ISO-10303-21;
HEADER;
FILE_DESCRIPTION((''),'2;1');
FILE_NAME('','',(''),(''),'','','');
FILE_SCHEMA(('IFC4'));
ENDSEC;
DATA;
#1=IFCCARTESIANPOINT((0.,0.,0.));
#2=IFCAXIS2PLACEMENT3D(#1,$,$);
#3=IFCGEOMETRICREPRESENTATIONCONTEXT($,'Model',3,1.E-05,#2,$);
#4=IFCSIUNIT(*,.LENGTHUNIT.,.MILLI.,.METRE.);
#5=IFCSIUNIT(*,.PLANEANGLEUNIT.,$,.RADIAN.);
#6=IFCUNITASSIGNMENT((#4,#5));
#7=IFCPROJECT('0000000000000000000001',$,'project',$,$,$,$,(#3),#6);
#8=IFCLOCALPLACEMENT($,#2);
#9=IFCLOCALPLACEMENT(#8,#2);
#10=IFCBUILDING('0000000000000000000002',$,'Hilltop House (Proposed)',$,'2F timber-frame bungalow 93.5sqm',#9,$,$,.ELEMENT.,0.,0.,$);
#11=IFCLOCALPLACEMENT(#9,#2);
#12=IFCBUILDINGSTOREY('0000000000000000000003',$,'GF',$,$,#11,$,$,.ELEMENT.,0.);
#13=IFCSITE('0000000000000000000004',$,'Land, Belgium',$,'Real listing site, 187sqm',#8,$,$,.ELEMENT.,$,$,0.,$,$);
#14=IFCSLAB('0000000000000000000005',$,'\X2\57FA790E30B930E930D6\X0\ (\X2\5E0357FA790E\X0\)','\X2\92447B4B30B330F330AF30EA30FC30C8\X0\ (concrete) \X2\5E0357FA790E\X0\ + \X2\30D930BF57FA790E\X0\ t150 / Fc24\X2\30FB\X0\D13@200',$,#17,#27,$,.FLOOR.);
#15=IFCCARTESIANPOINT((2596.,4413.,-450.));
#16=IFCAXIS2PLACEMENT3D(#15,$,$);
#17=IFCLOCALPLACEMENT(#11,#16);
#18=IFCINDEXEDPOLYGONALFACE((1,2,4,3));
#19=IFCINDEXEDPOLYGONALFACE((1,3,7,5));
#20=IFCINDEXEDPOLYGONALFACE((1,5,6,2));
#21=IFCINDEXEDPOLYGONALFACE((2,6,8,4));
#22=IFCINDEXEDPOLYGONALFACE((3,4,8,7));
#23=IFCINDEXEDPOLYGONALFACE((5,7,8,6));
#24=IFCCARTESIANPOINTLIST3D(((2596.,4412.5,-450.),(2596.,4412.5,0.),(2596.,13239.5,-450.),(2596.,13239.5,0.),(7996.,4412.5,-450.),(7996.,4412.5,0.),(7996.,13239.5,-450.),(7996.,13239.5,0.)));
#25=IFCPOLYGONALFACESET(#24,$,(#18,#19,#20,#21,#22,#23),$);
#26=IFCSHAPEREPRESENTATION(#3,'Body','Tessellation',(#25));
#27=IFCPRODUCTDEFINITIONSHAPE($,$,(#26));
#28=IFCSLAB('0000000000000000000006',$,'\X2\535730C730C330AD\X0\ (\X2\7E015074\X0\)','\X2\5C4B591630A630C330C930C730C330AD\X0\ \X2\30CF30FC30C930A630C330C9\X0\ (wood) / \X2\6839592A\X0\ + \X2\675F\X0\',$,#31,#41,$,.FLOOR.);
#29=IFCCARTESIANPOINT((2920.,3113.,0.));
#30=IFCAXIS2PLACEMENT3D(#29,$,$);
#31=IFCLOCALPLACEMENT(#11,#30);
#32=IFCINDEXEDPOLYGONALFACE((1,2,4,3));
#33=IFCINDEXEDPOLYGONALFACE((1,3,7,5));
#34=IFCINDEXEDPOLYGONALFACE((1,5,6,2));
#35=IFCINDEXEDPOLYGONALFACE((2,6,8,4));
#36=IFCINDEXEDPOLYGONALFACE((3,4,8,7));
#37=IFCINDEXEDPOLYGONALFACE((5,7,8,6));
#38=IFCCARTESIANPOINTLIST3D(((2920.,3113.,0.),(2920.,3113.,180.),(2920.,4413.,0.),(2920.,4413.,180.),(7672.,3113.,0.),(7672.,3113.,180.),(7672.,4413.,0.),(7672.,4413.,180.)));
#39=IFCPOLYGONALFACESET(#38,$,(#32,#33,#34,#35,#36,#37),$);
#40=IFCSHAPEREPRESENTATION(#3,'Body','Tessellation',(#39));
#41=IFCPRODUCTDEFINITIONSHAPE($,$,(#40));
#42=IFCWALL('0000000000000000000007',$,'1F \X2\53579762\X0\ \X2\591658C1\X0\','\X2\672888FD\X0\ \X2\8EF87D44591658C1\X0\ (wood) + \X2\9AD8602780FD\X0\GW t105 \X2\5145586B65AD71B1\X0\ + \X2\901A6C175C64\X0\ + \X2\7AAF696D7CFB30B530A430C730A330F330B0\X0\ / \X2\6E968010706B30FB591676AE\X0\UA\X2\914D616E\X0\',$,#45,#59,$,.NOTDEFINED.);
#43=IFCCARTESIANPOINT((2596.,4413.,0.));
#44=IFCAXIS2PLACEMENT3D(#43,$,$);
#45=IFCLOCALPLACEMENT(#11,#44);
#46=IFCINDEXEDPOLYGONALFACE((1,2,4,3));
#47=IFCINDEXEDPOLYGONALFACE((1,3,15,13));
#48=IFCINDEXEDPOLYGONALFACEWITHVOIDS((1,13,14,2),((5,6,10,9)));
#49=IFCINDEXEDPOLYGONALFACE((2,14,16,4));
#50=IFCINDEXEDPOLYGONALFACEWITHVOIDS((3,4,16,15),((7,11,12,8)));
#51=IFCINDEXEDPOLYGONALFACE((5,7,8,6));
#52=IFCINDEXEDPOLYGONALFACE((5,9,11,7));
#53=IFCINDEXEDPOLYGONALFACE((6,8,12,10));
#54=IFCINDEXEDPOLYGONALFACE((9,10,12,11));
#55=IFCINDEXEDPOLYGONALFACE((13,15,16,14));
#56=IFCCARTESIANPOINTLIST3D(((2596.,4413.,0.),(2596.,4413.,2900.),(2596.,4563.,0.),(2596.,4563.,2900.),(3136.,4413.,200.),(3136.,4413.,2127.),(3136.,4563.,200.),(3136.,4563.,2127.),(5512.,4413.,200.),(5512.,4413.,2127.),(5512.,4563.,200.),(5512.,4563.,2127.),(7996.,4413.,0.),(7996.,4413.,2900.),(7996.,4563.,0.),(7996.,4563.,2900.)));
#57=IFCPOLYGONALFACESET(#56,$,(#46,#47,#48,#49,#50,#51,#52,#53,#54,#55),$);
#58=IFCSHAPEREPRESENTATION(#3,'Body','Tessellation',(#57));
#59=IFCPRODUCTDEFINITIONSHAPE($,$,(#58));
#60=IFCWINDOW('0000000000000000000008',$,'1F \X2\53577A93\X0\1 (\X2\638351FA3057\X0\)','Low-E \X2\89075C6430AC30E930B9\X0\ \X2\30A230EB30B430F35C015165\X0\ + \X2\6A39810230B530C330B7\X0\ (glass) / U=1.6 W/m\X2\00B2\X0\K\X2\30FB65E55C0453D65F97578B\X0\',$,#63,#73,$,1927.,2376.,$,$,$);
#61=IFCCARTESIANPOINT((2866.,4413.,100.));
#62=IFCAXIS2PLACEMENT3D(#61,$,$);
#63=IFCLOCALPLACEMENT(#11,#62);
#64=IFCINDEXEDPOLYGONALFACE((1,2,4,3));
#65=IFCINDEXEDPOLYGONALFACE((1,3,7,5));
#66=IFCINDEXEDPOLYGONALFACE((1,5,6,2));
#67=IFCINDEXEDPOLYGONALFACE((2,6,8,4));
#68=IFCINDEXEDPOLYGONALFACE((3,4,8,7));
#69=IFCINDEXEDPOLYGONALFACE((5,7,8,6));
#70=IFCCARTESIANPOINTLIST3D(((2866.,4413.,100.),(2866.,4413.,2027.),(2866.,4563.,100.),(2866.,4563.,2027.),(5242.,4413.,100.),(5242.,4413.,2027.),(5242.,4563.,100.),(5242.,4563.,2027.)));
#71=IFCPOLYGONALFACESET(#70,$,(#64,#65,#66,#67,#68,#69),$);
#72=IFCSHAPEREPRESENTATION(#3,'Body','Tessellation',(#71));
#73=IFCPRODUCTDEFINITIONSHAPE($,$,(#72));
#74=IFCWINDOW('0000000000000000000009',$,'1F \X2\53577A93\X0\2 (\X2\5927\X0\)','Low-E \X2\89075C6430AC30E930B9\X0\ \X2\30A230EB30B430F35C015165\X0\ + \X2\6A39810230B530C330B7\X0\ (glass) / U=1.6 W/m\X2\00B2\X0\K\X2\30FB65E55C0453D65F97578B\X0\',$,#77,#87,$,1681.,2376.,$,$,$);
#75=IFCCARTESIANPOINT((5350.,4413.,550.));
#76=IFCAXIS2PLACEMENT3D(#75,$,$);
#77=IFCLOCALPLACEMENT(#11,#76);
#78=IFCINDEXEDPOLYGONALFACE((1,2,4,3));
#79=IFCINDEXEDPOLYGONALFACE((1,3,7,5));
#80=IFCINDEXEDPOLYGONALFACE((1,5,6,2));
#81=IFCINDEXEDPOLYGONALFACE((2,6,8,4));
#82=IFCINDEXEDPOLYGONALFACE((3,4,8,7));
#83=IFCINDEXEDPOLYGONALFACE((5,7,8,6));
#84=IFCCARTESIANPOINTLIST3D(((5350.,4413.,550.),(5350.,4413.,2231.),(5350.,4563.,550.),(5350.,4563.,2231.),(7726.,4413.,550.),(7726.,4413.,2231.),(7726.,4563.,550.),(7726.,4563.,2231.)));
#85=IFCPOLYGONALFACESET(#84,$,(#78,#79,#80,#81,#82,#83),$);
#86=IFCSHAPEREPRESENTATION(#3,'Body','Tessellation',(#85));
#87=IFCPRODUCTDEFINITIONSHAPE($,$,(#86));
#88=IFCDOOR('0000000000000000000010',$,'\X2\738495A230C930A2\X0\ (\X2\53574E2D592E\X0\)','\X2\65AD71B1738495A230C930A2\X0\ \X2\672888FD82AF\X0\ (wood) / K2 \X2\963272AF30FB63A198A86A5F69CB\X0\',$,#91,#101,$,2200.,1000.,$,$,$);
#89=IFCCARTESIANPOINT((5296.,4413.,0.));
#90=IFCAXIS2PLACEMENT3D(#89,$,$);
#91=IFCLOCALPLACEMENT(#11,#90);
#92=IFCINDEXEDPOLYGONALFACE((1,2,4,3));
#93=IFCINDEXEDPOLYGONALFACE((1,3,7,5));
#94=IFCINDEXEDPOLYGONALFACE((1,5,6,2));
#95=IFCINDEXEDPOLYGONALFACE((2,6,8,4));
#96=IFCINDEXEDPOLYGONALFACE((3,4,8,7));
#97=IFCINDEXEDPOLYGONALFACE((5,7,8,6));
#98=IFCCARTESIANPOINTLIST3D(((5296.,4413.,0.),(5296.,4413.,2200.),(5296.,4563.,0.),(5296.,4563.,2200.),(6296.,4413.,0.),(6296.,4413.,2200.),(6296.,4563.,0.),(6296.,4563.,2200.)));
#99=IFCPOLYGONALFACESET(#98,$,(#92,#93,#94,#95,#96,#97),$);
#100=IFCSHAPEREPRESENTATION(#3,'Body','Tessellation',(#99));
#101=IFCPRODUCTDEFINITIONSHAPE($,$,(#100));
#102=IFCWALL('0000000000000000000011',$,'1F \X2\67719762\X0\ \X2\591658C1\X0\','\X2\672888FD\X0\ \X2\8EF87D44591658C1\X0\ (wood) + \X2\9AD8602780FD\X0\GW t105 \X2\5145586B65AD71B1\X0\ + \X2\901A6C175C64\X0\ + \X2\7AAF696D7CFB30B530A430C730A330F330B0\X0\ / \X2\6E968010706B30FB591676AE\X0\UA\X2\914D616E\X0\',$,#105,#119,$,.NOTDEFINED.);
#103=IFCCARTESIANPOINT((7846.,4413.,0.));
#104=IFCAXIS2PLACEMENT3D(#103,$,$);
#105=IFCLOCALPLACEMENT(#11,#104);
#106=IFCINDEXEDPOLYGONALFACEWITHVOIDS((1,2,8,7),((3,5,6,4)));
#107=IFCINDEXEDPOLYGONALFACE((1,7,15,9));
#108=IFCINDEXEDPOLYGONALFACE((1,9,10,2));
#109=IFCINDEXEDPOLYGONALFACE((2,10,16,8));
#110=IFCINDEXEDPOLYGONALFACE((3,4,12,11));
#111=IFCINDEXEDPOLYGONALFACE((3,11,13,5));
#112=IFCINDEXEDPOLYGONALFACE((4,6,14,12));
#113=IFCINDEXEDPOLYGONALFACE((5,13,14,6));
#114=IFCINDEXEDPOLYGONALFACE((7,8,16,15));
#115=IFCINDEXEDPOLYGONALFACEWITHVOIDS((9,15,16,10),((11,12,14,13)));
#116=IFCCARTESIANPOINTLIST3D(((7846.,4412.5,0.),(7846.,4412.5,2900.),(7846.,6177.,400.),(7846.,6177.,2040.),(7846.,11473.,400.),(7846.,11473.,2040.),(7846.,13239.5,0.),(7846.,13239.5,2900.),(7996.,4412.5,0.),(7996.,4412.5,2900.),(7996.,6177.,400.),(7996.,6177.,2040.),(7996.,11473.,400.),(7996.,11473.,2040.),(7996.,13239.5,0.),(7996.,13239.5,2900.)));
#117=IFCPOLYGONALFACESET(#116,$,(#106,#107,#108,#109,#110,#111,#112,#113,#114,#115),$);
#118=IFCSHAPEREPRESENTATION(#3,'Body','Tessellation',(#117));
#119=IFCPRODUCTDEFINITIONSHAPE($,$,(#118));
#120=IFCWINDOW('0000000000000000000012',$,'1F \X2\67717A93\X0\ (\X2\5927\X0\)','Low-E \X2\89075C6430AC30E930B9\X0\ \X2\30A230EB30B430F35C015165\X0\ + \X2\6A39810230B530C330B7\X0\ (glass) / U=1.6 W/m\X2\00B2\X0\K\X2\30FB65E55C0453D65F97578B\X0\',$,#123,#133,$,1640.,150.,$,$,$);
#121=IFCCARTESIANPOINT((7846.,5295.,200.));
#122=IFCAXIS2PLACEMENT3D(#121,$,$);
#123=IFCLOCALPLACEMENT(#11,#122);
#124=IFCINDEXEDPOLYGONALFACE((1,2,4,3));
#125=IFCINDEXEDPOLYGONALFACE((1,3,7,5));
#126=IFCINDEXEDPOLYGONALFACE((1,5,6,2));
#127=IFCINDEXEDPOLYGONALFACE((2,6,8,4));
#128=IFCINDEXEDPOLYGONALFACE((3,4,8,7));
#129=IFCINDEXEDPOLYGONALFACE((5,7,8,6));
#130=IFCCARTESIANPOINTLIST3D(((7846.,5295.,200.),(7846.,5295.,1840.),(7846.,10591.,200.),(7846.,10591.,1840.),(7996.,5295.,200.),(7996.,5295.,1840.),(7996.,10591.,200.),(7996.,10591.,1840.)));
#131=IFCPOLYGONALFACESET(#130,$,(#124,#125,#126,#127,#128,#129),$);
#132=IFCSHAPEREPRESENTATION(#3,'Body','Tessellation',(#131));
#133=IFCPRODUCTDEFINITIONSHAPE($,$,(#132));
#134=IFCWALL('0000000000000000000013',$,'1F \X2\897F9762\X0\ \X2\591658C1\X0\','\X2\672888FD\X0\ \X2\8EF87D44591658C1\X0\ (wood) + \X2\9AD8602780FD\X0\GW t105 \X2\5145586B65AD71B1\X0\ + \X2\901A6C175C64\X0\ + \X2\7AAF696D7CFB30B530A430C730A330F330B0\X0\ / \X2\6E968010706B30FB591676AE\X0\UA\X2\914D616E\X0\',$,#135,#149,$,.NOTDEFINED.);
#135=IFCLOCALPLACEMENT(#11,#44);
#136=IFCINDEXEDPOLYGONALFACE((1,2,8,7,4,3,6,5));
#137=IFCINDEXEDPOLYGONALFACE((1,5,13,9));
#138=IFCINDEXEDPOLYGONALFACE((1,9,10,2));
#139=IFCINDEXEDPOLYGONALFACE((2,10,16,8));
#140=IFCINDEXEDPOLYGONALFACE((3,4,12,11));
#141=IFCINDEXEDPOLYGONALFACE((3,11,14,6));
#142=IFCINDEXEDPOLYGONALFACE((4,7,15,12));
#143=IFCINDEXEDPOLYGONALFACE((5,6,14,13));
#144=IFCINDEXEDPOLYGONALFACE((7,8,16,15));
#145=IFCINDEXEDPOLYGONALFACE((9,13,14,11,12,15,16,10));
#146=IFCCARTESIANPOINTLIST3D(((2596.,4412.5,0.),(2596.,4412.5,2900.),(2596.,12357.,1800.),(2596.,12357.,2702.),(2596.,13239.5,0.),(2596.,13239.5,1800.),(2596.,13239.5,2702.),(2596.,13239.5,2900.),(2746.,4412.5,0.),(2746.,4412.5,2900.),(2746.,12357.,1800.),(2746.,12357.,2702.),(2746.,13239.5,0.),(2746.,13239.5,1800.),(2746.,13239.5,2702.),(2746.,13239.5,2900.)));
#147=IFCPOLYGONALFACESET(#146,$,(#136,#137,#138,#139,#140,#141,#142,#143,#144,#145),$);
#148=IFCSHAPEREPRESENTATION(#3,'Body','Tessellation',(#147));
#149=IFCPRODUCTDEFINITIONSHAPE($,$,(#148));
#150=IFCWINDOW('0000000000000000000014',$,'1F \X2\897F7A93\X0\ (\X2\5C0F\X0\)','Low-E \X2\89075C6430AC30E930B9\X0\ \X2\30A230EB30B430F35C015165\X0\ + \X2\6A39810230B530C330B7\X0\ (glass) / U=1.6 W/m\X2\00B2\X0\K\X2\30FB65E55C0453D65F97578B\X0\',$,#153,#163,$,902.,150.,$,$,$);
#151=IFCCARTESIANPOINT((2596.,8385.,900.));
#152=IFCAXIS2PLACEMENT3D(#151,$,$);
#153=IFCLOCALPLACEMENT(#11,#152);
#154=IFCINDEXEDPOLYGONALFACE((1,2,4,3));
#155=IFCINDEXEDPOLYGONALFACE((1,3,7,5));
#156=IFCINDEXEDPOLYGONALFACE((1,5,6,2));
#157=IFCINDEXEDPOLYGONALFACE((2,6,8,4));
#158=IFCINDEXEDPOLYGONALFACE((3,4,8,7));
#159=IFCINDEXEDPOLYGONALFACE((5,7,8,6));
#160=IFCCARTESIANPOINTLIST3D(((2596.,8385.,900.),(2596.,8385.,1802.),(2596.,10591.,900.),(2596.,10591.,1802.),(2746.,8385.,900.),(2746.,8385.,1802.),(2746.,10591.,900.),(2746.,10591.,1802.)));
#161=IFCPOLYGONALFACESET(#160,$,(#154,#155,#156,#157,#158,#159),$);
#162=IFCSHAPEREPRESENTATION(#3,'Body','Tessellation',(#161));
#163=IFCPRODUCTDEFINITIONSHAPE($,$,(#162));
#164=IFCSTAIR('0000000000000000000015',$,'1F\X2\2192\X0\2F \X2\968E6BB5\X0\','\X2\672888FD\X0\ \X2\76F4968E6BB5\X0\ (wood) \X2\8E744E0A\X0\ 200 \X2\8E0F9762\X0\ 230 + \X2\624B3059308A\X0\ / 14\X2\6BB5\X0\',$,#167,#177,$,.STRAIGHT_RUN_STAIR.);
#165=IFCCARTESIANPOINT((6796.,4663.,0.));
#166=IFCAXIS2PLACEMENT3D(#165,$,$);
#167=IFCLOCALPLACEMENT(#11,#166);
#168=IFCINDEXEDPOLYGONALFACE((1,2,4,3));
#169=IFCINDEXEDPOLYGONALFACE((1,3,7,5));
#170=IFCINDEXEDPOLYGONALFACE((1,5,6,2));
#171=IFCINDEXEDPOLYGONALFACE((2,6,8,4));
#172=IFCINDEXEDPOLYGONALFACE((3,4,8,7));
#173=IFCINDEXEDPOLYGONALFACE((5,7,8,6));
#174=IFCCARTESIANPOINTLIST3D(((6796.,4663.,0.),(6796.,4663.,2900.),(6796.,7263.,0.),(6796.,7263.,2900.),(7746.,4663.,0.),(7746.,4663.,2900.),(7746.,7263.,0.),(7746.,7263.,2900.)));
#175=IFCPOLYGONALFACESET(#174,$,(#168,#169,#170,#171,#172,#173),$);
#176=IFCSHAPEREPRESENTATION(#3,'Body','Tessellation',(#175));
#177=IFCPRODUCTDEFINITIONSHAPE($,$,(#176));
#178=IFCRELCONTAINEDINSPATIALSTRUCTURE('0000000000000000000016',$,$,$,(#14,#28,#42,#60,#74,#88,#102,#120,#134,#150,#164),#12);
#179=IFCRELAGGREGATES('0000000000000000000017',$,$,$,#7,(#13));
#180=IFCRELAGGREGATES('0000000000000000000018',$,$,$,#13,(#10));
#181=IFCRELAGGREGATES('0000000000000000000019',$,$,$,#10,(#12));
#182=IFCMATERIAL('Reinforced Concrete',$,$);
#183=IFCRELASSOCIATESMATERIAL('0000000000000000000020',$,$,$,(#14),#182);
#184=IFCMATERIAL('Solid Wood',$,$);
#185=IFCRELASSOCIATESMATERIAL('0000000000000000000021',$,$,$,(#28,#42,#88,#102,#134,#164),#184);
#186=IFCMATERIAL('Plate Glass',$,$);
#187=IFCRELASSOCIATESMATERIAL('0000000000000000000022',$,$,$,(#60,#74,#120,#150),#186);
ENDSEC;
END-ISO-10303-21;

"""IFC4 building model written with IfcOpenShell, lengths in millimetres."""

from ifc_helpers import new_model, si_unit, frame, frame_2d, origin, place, context, project, spatial, rectangle, extrude, material, element, fill, save


model = new_model("IFC4")

# Units and contexts
model_context = context("Model", 3, precision=1e-05, world=origin())
ifc_project = project(units=[si_unit("LENGTHUNIT", "METRE", prefix="MILLI"), si_unit("PLANEANGLEUNIT", "RADIAN")], contexts=[model_context])

# Site, building, storey
site_placement = place(None, origin())
site = spatial("IfcSite", under=ifc_project, at=site_placement, Name="Land, Belgium", ObjectType="Real listing site, 187sqm", CompositionType="ELEMENT", RefElevation=0.0)
building_placement = place(site_placement, origin())
building = spatial("IfcBuilding", under=site, at=building_placement, Name="Hilltop House (Proposed)", ObjectType="2F timber-frame bungalow 93.5sqm", CompositionType="ELEMENT", ElevationOfRefHeight=0.0, ElevationOfTerrain=0.0)
storey_placement = place(building_placement, origin())
storey = spatial("IfcBuildingStorey", under=building, at=storey_placement, Name="GF", CompositionType="ELEMENT", Elevation=0.0)

# Slabs
ifc_material_1 = material(Name="Reinforced Concrete")
slab_1_placement = place(storey_placement, frame((2596.0, 4413.0, -450.0)))
element("IfcSlab", 1, at=slab_1_placement, inside=storey, material=ifc_material_1, Name="基礎スラブ (布基礎)", Description="鉄筋コンクリート (concrete) 布基礎 + ベタ基礎 t150 / Fc24・D13@200", PredefinedType="FLOOR", context=model_context, shape_type="SweptSolid", body=[
    extrude(rectangle(XDim=5400.0, YDim=8827.0, at=frame_2d((2700.0, 4413.0))), frame((2596.0, 4413.0, -450.0)), (0.0, 0.0, 1.0), 450.0),
])
ifc_material_2 = material(Name="Solid Wood")
slab_2_placement = place(storey_placement, frame((2920.0, 3113.0, 0.0)))
element("IfcSlab", 2, at=slab_2_placement, inside=storey, material=ifc_material_2, Name="南デッキ (縁側)", Description="屋外ウッドデッキ ハードウッド (wood) / 根太 + 束", PredefinedType="FLOOR", context=model_context, shape_type="SweptSolid", body=[
    extrude(rectangle(XDim=4752.0, YDim=1300.0, at=frame_2d((2376.0, 650.0))), frame((2920.0, 3113.0, 0.0)), (0.0, 0.0, 1.0), 180.0),
])

# Wall, openings, windows, door
wall_1_placement = place(storey_placement, frame((2596.0, 4413.0, 0.0)))
wall_1 = element("IfcWall", 3, at=wall_1_placement, inside=storey, material=ifc_material_2, Name="1F 南面 外壁", Description="木製 軸組外壁 (wood) + 高性能GW t105 充填断熱 + 通気層 + 窯業系サイディング / 準耐火・外皮UA配慮", PredefinedType="NOTDEFINED", context=model_context, shape_type="SweptSolid", body=[
    extrude(rectangle(XDim=5400.0, YDim=150.0, at=frame_2d((2700.0, 75.0))), frame((2596.0, 4413.0, 0.0)), (0.0, 0.0, 1.0), 2900.0),
])
opening_1_placement = place(storey_placement, frame((2866.0, 4413.0, 100.0)))
opening_1 = element("IfcOpeningElement", 4, at=opening_1_placement, cuts=wall_1, PredefinedType="NOTDEFINED", context=model_context, shape_type="SweptSolid", body=[
    extrude(rectangle(XDim=2376.0, YDim=150.0, at=frame_2d((1188.0, 75.0))), frame((2866.0, 4413.0, 100.0)), (0.0, 0.0, 1.0), 1927.0),
])
opening_2_placement = place(storey_placement, frame((5350.0, 4413.0, 550.0)))
opening_2 = element("IfcOpeningElement", 5, at=opening_2_placement, cuts=wall_1, PredefinedType="NOTDEFINED", context=model_context, shape_type="SweptSolid", body=[
    extrude(rectangle(XDim=2376.0, YDim=150.0, at=frame_2d((1188.0, 75.0))), frame((5350.0, 4413.0, 550.0)), (0.0, 0.0, 1.0), 1681.0),
])
opening_3_placement = place(storey_placement, frame((5296.0, 4413.0, 0.0)))
opening_3 = element("IfcOpeningElement", 6, at=opening_3_placement, cuts=wall_1, PredefinedType="NOTDEFINED", context=model_context, shape_type="SweptSolid", body=[
    extrude(rectangle(XDim=1000.0, YDim=150.0, at=frame_2d((500.0, 75.0))), frame((5296.0, 4413.0, 0.0)), (0.0, 0.0, 1.0), 2200.0),
])
ifc_material_3 = material(Name="Plate Glass")
window_1_placement = place(storey_placement, frame((2866.0, 4413.0, 100.0)))
window_1 = element("IfcWindow", 7, at=window_1_placement, inside=storey, material=ifc_material_3, Name="1F 南窓1 (掃出し)", Description="Low-E 複層ガラス アルゴン封入 + 樹脂サッシ (glass) / U=1.6 W/m²K・日射取得型", OverallHeight=1927.0, OverallWidth=2376.0, context=model_context, shape_type="SweptSolid", body=[
    extrude(rectangle(XDim=2376.0, YDim=150.0, at=frame_2d((1188.0, 75.0))), frame((2866.0, 4413.0, 100.0)), (0.0, 0.0, 1.0), 1927.0),
])
fill(opening_1, window_1)
window_2_placement = place(storey_placement, frame((5350.0, 4413.0, 550.0)))
window_2 = element("IfcWindow", 8, at=window_2_placement, inside=storey, material=ifc_material_3, Name="1F 南窓2 (大)", Description="Low-E 複層ガラス アルゴン封入 + 樹脂サッシ (glass) / U=1.6 W/m²K・日射取得型", OverallHeight=1681.0, OverallWidth=2376.0, context=model_context, shape_type="SweptSolid", body=[
    extrude(rectangle(XDim=2376.0, YDim=150.0, at=frame_2d((1188.0, 75.0))), frame((5350.0, 4413.0, 550.0)), (0.0, 0.0, 1.0), 1681.0),
])
fill(opening_2, window_2)
door_placement = place(storey_placement, frame((5296.0, 4413.0, 0.0)))
door = element("IfcDoor", 9, at=door_placement, inside=storey, material=ifc_material_2, Name="玄関ドア (南中央)", Description="断熱玄関ドア 木製芯 (wood) / K2 防犯・採風機構", OverallHeight=2200.0, OverallWidth=1000.0, context=model_context, shape_type="SweptSolid", body=[
    extrude(rectangle(XDim=1000.0, YDim=150.0, at=frame_2d((500.0, 75.0))), frame((5296.0, 4413.0, 0.0)), (0.0, 0.0, 1.0), 2200.0),
])
fill(opening_3, door)

# Walls, openings, windows
wall_2_placement = place(storey_placement, frame((7846.0, 4413.0, 0.0)))
wall_2 = element("IfcWall", 10, at=wall_2_placement, inside=storey, material=ifc_material_2, Name="1F 東面 外壁", Description="木製 軸組外壁 (wood) + 高性能GW t105 充填断熱 + 通気層 + 窯業系サイディング / 準耐火・外皮UA配慮", PredefinedType="NOTDEFINED", context=model_context, shape_type="SweptSolid", body=[
    extrude(rectangle(XDim=150.0, YDim=8827.0, at=frame_2d((75.0, 4413.0))), frame((7846.0, 4413.0, 0.0)), (0.0, 0.0, 1.0), 2900.0),
])
opening_4_placement = place(storey_placement, frame((7846.0, 5295.0, 200.0)))
opening_4 = element("IfcOpeningElement", 11, at=opening_4_placement, cuts=wall_2, PredefinedType="NOTDEFINED", context=model_context, shape_type="SweptSolid", body=[
    extrude(rectangle(XDim=150.0, YDim=5296.0, at=frame_2d((75.0, 2648.0))), frame((7846.0, 5295.0, 200.0)), (0.0, 0.0, 1.0), 1640.0),
])
window_3_placement = place(storey_placement, frame((7846.0, 5295.0, 200.0)))
window_3 = element("IfcWindow", 12, at=window_3_placement, inside=storey, material=ifc_material_3, Name="1F 東窓 (大)", Description="Low-E 複層ガラス アルゴン封入 + 樹脂サッシ (glass) / U=1.6 W/m²K・日射取得型", OverallHeight=1640.0, OverallWidth=150.0, context=model_context, shape_type="SweptSolid", body=[
    extrude(rectangle(XDim=150.0, YDim=5296.0, at=frame_2d((75.0, 2648.0))), frame((7846.0, 5295.0, 200.0)), (0.0, 0.0, 1.0), 1640.0),
])
fill(opening_4, window_3)
wall_3_placement = place(storey_placement, frame((2596.0, 4413.0, 0.0)))
wall_3 = element("IfcWall", 13, at=wall_3_placement, inside=storey, material=ifc_material_2, Name="1F 西面 外壁", Description="木製 軸組外壁 (wood) + 高性能GW t105 充填断熱 + 通気層 + 窯業系サイディング / 準耐火・外皮UA配慮", PredefinedType="NOTDEFINED", context=model_context, shape_type="SweptSolid", body=[
    extrude(rectangle(XDim=150.0, YDim=8827.0, at=frame_2d((75.0, 4413.0))), frame((2596.0, 4413.0, 0.0)), (0.0, 0.0, 1.0), 2900.0),
])
opening_5_placement = place(storey_placement, frame((2596.0, 8385.0, 900.0)))
opening_5 = element("IfcOpeningElement", 14, at=opening_5_placement, cuts=wall_3, PredefinedType="NOTDEFINED", context=model_context, shape_type="SweptSolid", body=[
    extrude(rectangle(XDim=150.0, YDim=2206.0, at=frame_2d((75.0, 1103.0))), frame((2596.0, 8385.0, 900.0)), (0.0, 0.0, 1.0), 902.0),
])
window_4_placement = place(storey_placement, frame((2596.0, 8385.0, 900.0)))
window_4 = element("IfcWindow", 15, at=window_4_placement, inside=storey, material=ifc_material_3, Name="1F 西窓 (小)", Description="Low-E 複層ガラス アルゴン封入 + 樹脂サッシ (glass) / U=1.6 W/m²K・日射取得型", OverallHeight=902.0, OverallWidth=150.0, context=model_context, shape_type="SweptSolid", body=[
    extrude(rectangle(XDim=150.0, YDim=2206.0, at=frame_2d((75.0, 1103.0))), frame((2596.0, 8385.0, 900.0)), (0.0, 0.0, 1.0), 902.0),
])
fill(opening_5, window_4)

# Stair
stair_placement = place(storey_placement, frame((6796.0, 4663.0, 0.0)))
element("IfcStair", 16, at=stair_placement, inside=storey, material=ifc_material_2, Name="1F→2F 階段", Description="木製 直階段 (wood) 蹴上 200 踏面 230 + 手すり / 14段", PredefinedType="STRAIGHT_RUN_STAIR", context=model_context, shape_type="SweptSolid", body=[
    extrude(rectangle(XDim=950.0, YDim=2600.0, at=frame_2d((475.0, 1300.0))), frame((6796.0, 4663.0, 0.0)), (0.0, 0.0, 1.0), 2900.0),
])

save(model, "model.ifc")
